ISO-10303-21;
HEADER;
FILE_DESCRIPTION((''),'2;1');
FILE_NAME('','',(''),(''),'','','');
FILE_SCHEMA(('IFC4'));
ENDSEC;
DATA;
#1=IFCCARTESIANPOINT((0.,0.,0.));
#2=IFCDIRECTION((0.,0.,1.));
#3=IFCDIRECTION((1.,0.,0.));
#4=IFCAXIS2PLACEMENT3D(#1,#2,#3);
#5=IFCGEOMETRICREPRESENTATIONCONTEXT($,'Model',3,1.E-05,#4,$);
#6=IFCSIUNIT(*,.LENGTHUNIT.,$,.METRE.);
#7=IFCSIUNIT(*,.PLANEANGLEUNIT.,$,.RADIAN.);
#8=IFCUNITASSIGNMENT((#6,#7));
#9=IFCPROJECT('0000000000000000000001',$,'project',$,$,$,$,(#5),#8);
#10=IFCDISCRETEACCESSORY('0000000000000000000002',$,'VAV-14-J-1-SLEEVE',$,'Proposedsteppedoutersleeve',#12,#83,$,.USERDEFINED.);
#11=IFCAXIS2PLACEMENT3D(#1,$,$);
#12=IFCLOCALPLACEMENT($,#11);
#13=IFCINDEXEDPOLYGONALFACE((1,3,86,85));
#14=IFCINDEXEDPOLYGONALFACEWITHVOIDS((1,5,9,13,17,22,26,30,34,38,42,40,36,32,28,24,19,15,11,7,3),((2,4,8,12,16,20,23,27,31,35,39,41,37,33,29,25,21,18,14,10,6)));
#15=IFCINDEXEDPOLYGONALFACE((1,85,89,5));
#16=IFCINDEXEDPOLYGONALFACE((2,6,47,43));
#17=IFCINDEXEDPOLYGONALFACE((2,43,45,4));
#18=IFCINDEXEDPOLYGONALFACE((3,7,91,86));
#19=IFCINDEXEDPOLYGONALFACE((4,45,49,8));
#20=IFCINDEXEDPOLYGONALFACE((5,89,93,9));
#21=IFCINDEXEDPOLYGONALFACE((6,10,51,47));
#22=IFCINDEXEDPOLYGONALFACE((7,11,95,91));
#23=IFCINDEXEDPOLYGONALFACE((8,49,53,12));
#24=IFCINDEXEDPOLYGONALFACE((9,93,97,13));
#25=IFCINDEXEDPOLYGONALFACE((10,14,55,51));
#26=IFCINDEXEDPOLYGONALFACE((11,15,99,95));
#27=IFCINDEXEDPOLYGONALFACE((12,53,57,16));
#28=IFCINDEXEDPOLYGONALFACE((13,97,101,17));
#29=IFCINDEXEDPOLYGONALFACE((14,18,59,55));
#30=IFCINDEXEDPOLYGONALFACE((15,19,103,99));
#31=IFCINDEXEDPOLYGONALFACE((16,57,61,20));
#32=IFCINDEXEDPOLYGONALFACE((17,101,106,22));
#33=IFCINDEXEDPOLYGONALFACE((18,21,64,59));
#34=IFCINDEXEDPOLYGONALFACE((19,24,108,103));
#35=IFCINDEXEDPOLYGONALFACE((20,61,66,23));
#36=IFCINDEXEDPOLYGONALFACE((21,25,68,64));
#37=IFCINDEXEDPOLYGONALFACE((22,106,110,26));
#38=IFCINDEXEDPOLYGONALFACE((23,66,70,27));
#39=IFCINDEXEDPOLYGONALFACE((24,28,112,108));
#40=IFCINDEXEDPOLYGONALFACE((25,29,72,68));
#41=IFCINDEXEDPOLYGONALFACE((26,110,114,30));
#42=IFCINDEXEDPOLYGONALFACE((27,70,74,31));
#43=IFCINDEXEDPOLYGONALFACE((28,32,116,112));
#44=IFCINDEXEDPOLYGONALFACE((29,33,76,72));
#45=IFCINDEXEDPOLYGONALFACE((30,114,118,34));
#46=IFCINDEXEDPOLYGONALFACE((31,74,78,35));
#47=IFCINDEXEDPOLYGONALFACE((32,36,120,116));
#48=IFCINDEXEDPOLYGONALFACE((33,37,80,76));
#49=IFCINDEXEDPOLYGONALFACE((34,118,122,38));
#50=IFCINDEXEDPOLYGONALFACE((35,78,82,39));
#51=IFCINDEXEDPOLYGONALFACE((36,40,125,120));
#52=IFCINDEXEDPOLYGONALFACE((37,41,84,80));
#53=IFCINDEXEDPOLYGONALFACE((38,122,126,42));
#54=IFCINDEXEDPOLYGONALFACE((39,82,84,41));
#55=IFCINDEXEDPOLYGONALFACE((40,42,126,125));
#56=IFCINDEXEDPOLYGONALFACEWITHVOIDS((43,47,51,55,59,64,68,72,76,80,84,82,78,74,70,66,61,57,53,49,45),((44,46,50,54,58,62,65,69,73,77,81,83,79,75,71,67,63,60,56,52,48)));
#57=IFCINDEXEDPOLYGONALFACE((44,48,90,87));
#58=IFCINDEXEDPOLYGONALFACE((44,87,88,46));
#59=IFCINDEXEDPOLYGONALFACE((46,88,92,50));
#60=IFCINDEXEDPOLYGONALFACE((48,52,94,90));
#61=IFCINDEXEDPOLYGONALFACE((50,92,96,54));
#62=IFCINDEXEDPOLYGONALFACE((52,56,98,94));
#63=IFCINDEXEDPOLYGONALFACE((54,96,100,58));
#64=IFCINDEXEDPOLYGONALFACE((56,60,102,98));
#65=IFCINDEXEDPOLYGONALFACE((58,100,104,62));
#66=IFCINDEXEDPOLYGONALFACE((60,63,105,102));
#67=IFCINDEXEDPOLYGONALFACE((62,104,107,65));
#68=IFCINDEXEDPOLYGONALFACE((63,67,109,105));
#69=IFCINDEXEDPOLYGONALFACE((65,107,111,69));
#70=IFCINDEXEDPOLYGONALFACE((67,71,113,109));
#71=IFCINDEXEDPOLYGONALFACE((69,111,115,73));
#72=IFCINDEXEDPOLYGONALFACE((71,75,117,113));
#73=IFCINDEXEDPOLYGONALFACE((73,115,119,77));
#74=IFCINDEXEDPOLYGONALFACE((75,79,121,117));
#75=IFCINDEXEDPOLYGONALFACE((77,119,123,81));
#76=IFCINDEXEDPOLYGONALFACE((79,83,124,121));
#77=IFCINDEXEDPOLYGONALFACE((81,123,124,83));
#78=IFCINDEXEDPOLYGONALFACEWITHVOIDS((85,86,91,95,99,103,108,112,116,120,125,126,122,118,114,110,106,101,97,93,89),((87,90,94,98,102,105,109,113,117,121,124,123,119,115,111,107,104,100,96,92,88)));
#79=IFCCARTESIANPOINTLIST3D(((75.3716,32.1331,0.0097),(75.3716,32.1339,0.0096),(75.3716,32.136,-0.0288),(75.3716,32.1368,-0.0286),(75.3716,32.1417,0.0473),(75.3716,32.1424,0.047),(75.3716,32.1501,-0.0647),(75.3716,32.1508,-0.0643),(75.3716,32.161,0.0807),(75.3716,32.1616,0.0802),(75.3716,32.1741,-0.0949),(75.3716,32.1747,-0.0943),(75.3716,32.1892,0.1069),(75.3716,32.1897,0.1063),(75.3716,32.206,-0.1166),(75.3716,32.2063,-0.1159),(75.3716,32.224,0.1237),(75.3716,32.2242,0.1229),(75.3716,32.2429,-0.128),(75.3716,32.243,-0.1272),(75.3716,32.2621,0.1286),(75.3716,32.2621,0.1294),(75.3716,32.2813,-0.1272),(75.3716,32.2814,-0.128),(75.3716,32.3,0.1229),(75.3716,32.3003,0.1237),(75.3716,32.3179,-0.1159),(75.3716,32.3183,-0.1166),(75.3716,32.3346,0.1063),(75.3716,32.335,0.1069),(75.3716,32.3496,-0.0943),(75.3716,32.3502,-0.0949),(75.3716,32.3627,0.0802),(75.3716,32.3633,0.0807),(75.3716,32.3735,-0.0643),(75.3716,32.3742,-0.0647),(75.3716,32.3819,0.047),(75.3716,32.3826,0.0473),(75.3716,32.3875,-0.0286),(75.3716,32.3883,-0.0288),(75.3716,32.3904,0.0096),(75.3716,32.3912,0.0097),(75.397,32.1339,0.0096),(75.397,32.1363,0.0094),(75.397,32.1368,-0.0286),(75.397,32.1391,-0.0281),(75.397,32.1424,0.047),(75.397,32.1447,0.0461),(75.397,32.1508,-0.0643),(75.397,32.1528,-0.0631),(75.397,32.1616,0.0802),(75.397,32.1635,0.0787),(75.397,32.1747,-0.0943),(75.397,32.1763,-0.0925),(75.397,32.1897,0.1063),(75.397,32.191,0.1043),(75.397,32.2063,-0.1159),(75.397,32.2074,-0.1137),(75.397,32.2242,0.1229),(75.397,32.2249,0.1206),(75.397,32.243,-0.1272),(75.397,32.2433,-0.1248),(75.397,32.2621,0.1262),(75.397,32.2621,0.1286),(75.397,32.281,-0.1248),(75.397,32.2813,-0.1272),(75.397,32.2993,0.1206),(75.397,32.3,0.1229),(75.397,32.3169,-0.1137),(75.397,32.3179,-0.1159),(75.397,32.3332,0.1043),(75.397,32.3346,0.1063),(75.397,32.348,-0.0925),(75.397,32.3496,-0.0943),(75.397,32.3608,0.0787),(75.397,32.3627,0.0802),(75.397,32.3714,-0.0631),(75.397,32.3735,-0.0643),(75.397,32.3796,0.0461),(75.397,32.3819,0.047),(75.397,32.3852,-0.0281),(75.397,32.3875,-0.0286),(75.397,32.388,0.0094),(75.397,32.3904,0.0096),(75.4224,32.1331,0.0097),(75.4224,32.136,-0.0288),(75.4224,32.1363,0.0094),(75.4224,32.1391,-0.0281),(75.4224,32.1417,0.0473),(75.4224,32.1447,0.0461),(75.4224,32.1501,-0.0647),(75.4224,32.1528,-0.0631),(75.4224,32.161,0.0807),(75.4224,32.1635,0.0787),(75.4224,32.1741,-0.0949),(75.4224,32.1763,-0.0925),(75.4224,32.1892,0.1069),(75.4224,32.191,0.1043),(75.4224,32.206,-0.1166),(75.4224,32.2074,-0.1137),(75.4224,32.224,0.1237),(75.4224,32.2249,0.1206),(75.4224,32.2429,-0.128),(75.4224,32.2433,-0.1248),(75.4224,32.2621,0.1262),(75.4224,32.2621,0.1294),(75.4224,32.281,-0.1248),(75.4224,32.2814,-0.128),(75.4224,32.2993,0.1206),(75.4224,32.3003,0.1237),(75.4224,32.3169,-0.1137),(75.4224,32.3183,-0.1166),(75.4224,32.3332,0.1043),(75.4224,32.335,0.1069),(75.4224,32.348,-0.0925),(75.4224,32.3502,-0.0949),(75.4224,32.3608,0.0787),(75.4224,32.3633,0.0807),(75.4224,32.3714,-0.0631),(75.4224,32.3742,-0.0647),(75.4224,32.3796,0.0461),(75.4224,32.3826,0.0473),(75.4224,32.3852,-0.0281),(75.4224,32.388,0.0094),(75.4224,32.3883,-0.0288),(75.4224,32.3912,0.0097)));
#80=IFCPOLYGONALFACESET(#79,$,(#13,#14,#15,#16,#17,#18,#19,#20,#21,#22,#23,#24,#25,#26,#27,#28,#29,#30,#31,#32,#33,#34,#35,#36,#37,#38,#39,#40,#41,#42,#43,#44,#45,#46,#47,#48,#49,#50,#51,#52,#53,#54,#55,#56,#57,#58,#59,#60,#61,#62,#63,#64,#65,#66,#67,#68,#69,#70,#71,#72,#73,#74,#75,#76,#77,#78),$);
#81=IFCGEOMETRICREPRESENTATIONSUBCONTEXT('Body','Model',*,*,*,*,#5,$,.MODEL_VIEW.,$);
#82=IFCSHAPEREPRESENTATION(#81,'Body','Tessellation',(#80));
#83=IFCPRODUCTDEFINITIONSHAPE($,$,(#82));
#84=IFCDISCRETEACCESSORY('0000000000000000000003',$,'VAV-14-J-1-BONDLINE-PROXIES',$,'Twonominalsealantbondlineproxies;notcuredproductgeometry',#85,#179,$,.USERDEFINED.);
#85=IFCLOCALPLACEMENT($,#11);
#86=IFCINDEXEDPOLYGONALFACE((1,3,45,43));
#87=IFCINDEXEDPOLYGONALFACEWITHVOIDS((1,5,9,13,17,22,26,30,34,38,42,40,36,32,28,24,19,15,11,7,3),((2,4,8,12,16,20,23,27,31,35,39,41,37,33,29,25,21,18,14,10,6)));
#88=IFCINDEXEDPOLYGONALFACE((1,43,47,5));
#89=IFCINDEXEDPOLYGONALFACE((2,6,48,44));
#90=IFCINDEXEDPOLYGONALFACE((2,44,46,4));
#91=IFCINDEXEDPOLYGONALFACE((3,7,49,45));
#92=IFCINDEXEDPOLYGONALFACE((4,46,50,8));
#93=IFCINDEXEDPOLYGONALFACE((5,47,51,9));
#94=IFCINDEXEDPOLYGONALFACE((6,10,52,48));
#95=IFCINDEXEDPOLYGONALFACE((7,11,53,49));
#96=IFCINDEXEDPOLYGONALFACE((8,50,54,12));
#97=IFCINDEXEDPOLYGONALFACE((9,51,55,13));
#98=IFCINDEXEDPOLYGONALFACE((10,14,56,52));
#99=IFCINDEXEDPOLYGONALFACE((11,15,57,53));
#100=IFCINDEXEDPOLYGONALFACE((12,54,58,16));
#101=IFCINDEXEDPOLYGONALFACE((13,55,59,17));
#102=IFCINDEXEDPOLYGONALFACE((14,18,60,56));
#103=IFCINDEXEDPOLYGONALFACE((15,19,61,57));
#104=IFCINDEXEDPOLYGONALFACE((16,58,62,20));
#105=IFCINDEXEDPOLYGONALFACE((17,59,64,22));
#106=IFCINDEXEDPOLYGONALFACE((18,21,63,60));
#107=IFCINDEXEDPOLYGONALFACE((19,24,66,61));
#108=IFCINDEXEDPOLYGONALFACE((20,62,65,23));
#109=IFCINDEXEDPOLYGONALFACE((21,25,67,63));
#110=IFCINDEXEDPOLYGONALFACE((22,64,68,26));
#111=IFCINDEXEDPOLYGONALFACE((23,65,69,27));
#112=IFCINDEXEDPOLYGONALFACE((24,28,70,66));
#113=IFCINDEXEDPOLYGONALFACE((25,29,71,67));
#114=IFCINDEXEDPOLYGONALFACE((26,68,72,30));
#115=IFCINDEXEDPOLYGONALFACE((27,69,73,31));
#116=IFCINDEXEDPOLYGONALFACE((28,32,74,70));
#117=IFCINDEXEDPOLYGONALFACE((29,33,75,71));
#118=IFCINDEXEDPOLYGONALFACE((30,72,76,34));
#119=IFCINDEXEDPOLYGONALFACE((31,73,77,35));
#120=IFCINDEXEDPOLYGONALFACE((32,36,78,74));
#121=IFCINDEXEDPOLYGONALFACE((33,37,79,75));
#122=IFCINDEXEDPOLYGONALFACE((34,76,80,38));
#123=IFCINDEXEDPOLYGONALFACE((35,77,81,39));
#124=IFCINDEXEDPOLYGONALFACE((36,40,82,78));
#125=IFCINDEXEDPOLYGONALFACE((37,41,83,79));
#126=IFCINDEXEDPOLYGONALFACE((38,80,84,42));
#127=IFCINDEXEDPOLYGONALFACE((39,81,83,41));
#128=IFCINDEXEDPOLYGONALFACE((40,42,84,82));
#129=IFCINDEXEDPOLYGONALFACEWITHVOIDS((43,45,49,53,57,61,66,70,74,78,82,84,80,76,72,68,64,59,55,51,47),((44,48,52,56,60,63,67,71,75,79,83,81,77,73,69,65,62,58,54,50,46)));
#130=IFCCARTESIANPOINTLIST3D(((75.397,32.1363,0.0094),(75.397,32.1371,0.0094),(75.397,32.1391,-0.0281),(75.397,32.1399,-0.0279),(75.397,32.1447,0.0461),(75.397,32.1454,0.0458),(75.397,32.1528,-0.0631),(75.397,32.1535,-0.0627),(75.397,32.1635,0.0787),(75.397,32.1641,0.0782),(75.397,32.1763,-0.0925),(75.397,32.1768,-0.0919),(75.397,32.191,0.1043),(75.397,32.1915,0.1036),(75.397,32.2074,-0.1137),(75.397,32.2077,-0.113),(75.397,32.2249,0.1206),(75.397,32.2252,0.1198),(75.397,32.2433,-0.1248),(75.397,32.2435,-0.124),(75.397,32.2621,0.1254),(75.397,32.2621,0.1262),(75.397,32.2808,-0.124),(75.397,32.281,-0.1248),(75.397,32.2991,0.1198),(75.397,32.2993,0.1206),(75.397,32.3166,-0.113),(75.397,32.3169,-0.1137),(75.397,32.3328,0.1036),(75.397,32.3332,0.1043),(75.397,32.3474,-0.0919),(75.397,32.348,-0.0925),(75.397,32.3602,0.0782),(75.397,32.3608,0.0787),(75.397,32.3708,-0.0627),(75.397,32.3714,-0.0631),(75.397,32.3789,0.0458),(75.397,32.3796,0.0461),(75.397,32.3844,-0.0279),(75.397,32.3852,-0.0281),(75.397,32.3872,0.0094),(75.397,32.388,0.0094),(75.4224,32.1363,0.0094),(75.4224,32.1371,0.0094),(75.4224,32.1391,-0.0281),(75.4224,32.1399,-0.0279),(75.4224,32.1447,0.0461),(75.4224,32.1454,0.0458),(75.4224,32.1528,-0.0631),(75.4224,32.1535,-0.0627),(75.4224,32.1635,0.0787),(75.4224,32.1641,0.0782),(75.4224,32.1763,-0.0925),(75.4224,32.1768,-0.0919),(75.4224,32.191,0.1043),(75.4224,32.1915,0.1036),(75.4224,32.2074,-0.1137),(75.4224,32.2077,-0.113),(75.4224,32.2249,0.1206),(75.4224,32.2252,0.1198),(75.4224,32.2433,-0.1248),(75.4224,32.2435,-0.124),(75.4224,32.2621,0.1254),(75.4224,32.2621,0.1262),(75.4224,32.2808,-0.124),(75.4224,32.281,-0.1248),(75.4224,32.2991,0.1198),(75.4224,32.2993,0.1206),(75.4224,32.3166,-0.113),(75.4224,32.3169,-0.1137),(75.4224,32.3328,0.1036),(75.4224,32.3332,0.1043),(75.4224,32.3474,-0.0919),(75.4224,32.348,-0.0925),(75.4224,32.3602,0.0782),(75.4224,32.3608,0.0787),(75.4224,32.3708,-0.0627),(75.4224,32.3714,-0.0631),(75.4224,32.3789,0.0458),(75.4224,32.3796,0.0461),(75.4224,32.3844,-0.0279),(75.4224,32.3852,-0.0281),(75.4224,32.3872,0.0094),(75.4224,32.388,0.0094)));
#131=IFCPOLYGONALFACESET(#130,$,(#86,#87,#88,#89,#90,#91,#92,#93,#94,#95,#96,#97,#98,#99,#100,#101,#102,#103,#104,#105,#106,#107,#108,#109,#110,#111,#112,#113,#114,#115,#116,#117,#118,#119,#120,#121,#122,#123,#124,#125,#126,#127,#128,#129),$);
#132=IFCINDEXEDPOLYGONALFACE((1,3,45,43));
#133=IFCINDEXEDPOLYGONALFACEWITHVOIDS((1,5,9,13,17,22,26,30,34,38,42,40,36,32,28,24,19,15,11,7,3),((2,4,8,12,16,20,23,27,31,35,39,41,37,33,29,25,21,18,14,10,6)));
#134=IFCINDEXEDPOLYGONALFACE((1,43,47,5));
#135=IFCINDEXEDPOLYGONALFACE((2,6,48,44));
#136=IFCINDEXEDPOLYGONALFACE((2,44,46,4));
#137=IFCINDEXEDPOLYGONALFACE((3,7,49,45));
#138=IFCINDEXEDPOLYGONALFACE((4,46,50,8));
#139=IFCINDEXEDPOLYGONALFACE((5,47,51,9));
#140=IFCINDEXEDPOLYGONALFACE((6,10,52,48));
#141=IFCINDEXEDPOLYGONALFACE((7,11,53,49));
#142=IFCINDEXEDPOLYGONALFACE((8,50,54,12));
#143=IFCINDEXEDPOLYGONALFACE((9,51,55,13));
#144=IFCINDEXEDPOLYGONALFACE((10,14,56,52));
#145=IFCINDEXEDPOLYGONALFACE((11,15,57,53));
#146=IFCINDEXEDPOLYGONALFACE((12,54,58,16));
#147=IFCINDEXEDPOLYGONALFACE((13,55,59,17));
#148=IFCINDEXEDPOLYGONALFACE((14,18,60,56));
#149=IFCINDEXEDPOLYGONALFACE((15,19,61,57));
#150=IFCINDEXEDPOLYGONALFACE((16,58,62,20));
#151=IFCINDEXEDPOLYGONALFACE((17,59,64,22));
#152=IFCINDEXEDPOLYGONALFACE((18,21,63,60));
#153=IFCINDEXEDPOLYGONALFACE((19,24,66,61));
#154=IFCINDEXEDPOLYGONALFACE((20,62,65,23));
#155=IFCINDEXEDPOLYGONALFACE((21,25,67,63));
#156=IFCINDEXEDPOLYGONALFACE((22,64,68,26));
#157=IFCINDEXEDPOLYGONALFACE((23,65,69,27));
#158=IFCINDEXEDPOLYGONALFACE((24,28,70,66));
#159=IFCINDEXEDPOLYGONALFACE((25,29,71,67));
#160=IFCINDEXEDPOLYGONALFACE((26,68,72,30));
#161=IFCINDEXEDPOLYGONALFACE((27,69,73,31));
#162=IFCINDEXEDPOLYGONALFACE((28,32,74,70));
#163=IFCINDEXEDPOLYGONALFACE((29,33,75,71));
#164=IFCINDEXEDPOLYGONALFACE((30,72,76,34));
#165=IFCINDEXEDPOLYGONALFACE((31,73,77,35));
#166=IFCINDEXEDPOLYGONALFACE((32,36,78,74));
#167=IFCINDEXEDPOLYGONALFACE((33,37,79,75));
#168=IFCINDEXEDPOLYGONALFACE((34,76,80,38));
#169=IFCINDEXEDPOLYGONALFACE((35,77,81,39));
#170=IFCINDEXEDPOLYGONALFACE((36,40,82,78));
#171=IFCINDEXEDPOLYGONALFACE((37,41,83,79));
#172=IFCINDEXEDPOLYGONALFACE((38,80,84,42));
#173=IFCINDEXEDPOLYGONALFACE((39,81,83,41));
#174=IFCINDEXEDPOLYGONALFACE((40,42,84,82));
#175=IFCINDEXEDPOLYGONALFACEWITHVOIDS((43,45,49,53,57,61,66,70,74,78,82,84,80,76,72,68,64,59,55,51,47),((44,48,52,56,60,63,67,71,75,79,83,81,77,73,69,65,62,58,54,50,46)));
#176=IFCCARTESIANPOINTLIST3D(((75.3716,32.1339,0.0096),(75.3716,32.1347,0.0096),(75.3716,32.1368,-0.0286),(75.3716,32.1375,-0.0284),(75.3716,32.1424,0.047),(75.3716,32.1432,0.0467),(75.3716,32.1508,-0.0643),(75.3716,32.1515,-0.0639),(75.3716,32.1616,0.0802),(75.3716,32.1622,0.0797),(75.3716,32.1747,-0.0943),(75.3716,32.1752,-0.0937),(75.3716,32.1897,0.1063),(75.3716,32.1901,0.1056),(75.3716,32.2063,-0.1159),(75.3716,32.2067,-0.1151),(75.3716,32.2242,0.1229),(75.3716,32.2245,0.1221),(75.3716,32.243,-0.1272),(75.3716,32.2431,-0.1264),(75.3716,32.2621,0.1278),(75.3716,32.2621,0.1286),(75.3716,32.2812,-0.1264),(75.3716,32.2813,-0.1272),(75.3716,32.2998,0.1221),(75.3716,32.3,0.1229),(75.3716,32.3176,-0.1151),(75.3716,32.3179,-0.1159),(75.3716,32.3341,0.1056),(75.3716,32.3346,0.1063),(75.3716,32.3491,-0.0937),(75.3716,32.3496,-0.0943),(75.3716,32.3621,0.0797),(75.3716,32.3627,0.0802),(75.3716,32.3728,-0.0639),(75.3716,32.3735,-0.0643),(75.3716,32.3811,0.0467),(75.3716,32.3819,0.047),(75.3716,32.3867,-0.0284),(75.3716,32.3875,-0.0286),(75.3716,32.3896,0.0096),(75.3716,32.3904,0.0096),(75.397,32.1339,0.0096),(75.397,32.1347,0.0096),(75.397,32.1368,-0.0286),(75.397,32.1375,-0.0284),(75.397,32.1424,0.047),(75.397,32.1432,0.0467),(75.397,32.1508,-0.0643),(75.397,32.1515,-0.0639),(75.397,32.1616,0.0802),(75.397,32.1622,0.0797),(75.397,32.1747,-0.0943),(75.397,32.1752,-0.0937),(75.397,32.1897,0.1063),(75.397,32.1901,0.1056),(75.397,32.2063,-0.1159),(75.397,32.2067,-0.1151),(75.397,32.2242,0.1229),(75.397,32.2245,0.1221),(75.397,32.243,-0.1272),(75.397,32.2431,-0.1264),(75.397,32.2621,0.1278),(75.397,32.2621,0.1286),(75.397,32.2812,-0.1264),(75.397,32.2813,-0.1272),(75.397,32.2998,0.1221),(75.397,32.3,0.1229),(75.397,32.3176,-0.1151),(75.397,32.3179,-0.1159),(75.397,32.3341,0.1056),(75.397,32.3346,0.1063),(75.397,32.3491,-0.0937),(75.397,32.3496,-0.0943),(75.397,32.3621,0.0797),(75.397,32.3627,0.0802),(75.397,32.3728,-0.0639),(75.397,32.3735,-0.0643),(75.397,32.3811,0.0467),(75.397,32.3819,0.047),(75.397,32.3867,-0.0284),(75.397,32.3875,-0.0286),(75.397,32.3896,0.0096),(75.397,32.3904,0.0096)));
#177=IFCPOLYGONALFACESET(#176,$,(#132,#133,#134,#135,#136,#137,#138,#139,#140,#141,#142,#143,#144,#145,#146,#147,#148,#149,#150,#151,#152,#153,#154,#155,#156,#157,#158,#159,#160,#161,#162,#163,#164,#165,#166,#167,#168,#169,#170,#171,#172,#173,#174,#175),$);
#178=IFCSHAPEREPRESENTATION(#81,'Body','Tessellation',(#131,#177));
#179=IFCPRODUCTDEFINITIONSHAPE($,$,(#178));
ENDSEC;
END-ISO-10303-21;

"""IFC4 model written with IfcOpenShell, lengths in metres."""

from ifc_helpers import new_model, entity, si_unit, frame, origin_with_axes, place, context, subcontext, project, element, save


model = new_model("IFC4")

# Units and contexts
model_context = context("Model", 3, precision=1e-05, world=origin_with_axes())
body_context = subcontext(model_context, "Body", "Model", "MODEL_VIEW")
ifc_project = project(units=[si_unit("LENGTHUNIT", "METRE"), si_unit("PLANEANGLEUNIT", "RADIAN")], contexts=[model_context])

# Discrete accessories
discrete_accessory_1_placement = place(None, frame((75.397, 32.2621, 0.0), z_axis=(0.0, -1.0, 0.0), x_axis=(0.0, 0.0, 1.0)))
element("IfcDiscreteAccessory", 1, at=discrete_accessory_1_placement, Name="VAV-14-J-1-SLEEVE", ObjectType="Proposedsteppedoutersleeve", PredefinedType="USERDEFINED", context=body_context, shape_type="SweptSolid", body=[
    entity("IfcRevolvedAreaSolid", entity("IfcArbitraryClosedProfileDef", "AREA", None, entity("IfcPolyline", [entity("IfcCartesianPoint", [0.1262, -0.0254]), entity("IfcCartesianPoint", [0.1294, -0.0254]), entity("IfcCartesianPoint", [0.1294, 0.0254]), entity("IfcCartesianPoint", [0.1286, 0.0254]), entity("IfcCartesianPoint", [0.1286, 0.0]), entity("IfcCartesianPoint", [0.1262, 0.0]), entity("IfcCartesianPoint", [0.1262, -0.0254])])), entity("IfcAxis2Placement3D", entity("IfcCartesianPoint", [0.0, 0.0, 0.0])), entity("IfcAxis1Placement", entity("IfcCartesianPoint", [0.0, 0.0, 0.0]), entity("IfcDirection", [0.0, 1.0, 0.0])), 6.283185),
])
discrete_accessory_2_placement = place(None, frame((75.397, 32.2621, 0.0), z_axis=(0.0, -1.0, 0.0), x_axis=(0.0, 0.0, 1.0)))
element("IfcDiscreteAccessory", 2, at=discrete_accessory_2_placement, Name="VAV-14-J-1-BONDLINE-PROXIES", ObjectType="Twonominalsealantbondlineproxies;notcuredproductgeometry", PredefinedType="USERDEFINED", context=body_context, shape_type="SweptSolid", body=[
    entity("IfcRevolvedAreaSolid", entity("IfcArbitraryClosedProfileDef", "AREA", None, entity("IfcPolyline", [entity("IfcCartesianPoint", [0.1254, -0.0254]), entity("IfcCartesianPoint", [0.1262, -0.0254]), entity("IfcCartesianPoint", [0.1262, 0.0]), entity("IfcCartesianPoint", [0.1254, 0.0]), entity("IfcCartesianPoint", [0.1254, -0.0254])])), entity("IfcAxis2Placement3D", entity("IfcCartesianPoint", [0.0, 0.0, 0.0])), entity("IfcAxis1Placement", entity("IfcCartesianPoint", [0.0, 0.0, 0.0]), entity("IfcDirection", [0.0, 1.0, 0.0])), 6.283185),
    entity("IfcRevolvedAreaSolid", entity("IfcArbitraryClosedProfileDef", "AREA", None, entity("IfcPolyline", [entity("IfcCartesianPoint", [0.1278, 0.0]), entity("IfcCartesianPoint", [0.1286, 0.0]), entity("IfcCartesianPoint", [0.1286, 0.0254]), entity("IfcCartesianPoint", [0.1278, 0.0254]), entity("IfcCartesianPoint", [0.1278, 0.0])])), entity("IfcAxis2Placement3D", entity("IfcCartesianPoint", [0.0, 0.0, 0.0])), entity("IfcAxis1Placement", entity("IfcCartesianPoint", [0.0, 0.0, 0.0]), entity("IfcDirection", [0.0, 1.0, 0.0])), 6.283185),
])

save(model, "model.ifc")
